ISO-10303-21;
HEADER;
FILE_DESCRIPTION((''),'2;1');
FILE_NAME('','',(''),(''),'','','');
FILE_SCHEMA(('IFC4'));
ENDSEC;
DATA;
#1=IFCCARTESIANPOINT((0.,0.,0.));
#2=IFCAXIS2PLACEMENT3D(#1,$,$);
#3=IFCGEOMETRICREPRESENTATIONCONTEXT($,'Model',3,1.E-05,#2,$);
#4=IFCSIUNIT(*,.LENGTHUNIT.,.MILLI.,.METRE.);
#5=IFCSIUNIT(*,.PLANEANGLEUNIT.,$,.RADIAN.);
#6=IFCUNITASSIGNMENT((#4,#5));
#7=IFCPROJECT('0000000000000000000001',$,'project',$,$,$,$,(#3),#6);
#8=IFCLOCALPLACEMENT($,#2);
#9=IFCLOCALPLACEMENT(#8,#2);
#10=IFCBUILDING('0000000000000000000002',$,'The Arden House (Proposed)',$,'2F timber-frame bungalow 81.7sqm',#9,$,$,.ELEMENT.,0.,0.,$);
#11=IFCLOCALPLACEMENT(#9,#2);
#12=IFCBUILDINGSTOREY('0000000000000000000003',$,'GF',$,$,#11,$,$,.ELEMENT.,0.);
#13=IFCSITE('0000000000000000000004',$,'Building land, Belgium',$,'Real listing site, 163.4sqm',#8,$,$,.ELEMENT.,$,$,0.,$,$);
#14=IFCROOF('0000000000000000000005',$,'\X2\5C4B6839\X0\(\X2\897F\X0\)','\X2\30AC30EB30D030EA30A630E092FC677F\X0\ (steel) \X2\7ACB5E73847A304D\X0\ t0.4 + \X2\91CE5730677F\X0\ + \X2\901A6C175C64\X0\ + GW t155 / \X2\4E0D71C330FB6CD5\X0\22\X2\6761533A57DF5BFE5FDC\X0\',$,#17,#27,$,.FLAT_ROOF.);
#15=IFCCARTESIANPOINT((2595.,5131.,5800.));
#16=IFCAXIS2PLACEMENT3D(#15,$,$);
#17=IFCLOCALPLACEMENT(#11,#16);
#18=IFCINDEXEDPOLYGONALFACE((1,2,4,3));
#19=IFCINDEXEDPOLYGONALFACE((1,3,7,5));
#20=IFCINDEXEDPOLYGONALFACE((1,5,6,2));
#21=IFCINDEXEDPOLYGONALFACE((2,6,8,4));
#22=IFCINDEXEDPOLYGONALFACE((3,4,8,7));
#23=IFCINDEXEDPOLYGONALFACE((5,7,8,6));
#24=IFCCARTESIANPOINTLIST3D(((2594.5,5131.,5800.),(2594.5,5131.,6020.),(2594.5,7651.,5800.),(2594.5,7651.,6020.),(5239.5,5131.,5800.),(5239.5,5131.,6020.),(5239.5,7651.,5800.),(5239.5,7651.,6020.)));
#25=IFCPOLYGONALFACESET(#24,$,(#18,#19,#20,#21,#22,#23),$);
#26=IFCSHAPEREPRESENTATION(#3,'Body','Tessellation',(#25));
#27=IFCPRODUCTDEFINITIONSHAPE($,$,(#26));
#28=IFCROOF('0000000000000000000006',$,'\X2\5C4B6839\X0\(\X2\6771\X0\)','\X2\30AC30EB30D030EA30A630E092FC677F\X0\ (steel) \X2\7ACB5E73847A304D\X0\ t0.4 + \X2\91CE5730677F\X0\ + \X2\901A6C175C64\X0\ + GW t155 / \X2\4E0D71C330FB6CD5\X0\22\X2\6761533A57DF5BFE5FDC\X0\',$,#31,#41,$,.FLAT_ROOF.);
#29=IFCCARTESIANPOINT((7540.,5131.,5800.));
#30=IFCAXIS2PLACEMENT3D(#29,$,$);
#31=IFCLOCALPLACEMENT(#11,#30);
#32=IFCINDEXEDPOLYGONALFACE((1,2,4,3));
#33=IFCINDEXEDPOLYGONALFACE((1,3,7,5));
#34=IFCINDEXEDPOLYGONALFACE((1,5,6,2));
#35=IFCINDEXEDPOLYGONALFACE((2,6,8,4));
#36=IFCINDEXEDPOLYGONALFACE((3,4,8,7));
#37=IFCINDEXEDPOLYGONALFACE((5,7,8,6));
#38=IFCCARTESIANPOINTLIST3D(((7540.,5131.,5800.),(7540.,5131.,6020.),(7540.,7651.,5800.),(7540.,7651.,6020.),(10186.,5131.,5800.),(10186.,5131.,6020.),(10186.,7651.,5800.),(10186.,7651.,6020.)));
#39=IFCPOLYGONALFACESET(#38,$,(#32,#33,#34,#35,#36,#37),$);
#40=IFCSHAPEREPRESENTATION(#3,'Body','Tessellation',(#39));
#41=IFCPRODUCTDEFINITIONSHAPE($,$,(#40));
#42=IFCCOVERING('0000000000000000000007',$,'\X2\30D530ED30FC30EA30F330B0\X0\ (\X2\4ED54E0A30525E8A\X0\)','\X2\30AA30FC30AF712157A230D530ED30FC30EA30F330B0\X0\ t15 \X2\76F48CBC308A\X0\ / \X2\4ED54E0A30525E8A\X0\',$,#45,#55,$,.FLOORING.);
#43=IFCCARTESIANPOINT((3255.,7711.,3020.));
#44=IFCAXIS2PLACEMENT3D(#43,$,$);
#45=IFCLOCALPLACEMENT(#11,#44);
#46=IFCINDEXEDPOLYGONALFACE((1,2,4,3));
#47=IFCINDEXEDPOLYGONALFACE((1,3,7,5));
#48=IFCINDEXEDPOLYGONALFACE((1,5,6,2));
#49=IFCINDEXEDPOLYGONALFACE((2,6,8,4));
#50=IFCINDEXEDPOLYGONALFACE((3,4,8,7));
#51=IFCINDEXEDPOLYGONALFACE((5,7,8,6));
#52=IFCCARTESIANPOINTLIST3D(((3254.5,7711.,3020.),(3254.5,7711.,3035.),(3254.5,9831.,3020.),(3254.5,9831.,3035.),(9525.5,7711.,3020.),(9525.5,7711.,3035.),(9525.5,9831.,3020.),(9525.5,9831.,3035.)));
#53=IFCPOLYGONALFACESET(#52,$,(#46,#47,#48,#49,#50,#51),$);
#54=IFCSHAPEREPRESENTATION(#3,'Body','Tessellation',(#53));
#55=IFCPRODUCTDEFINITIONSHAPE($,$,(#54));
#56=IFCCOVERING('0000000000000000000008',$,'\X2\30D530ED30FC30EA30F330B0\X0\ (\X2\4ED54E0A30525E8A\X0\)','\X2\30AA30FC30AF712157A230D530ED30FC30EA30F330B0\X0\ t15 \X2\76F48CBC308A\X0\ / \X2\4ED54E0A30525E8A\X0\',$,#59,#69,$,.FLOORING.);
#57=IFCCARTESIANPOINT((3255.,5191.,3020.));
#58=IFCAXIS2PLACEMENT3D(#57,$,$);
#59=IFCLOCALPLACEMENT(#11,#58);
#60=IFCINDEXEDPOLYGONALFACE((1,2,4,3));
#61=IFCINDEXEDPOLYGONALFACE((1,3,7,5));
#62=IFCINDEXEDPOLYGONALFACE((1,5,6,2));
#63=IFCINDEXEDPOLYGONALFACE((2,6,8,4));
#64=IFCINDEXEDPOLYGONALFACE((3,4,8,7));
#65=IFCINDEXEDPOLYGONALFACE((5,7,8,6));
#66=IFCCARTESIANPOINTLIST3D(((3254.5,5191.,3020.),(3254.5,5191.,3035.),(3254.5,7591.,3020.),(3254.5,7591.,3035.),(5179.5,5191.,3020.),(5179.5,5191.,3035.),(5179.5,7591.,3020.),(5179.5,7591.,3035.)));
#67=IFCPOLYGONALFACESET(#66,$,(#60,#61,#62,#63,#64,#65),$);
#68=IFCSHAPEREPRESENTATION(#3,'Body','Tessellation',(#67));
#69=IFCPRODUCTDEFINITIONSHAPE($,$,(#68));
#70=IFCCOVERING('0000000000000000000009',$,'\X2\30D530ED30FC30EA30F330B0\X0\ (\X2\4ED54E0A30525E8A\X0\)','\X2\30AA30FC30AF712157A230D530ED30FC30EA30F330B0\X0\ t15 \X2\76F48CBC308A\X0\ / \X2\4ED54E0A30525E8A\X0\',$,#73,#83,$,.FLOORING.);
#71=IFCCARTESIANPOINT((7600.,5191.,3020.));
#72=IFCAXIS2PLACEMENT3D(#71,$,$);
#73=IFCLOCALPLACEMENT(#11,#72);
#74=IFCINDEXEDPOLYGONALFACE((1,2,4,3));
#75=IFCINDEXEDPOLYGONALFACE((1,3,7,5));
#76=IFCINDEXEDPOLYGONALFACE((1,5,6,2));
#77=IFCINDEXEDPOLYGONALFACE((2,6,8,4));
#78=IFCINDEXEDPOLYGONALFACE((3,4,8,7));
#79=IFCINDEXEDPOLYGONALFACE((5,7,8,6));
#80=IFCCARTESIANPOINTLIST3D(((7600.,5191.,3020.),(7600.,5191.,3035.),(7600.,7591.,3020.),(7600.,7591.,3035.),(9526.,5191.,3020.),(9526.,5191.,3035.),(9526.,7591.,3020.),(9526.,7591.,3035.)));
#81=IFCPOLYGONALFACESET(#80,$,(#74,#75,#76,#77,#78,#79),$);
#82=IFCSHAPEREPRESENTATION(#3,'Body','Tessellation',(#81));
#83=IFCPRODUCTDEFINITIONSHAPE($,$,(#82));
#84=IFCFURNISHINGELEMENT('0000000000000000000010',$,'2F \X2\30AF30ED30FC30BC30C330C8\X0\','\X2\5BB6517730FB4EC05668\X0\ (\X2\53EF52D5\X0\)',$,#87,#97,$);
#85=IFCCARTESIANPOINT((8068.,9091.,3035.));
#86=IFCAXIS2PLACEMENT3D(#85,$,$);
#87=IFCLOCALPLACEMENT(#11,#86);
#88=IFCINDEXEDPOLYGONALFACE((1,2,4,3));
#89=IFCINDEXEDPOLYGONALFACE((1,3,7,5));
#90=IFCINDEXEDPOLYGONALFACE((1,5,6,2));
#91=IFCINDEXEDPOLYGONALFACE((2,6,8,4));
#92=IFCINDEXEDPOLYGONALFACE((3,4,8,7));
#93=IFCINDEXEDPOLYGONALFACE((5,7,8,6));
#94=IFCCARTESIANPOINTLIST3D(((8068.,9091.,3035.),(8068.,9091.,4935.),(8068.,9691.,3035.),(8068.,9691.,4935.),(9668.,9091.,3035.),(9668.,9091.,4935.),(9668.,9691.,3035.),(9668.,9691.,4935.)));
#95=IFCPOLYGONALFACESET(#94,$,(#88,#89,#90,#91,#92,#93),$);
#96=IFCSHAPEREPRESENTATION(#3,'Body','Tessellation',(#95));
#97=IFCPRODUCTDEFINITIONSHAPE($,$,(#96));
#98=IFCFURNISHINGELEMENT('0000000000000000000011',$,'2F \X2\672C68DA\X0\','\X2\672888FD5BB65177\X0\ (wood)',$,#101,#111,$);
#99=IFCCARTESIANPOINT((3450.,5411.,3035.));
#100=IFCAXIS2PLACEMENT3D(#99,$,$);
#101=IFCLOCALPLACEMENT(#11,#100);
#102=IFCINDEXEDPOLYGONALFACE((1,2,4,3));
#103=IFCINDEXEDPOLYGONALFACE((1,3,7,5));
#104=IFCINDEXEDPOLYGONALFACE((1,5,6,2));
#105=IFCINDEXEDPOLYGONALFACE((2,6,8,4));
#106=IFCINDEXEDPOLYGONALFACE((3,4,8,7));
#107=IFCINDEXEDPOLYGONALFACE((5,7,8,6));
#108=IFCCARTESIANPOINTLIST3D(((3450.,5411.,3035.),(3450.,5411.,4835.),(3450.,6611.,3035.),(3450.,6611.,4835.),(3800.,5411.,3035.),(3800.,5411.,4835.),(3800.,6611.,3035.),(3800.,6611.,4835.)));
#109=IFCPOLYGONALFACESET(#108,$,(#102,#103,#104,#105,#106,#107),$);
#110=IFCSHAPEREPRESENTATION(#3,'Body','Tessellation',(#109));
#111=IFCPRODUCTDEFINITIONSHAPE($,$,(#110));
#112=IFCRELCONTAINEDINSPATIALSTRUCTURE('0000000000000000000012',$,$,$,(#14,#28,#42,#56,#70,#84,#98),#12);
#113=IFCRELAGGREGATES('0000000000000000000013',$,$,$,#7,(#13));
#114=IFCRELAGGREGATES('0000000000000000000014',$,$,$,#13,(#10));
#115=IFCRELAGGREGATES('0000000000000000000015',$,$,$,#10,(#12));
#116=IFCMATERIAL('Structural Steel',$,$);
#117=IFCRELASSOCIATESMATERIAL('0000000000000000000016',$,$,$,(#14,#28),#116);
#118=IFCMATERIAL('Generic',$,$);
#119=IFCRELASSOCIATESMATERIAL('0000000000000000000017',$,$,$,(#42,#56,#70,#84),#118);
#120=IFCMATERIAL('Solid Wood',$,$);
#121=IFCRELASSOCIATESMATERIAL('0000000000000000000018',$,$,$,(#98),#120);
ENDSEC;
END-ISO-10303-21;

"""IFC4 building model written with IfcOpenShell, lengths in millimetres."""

from ifc_helpers import new_model, si_unit, frame, frame_2d, origin, place, context, project, spatial, rectangle, extrude, material, element, save


model = new_model("IFC4")

# Units and contexts
model_context = context("Model", 3, precision=1e-05, world=origin())
ifc_project = project(units=[si_unit("LENGTHUNIT", "METRE", prefix="MILLI"), si_unit("PLANEANGLEUNIT", "RADIAN")], contexts=[model_context])

# Site, building, storey
site_placement = place(None, origin())
site = spatial("IfcSite", under=ifc_project, at=site_placement, Name="Building land, Belgium", ObjectType="Real listing site, 163.4sqm", CompositionType="ELEMENT", RefElevation=0.0)
building_placement = place(site_placement, origin())
building = spatial("IfcBuilding", under=site, at=building_placement, Name="The Arden House (Proposed)", ObjectType="2F timber-frame bungalow 81.7sqm", CompositionType="ELEMENT", ElevationOfRefHeight=0.0, ElevationOfTerrain=0.0)
storey_placement = place(building_placement, origin())
storey = spatial("IfcBuildingStorey", under=building, at=storey_placement, Name="GF", CompositionType="ELEMENT", Elevation=0.0)

# Shared definitions
ifc_material_1 = material(Name="Solid Wood")

# Roofs
ifc_material_2 = material(Name="Structural Steel")
roof_1_placement = place(storey_placement, frame((2595.0, 5131.0, 5800.0)))
element("IfcRoof", 1, at=roof_1_placement, inside=storey, material=ifc_material_2, Name="屋根(西)", Description="ガルバリウム鋼板 (steel) 立平葺き t0.4 + 野地板 + 通気層 + GW t155 / 不燃・法22条区域対応", PredefinedType="FLAT_ROOF", context=model_context, shape_type="SweptSolid", body=[
    extrude(rectangle(XDim=2645.0, YDim=2520.0, at=frame_2d((1322.0, 1260.0))), frame((2595.0, 5131.0, 5800.0)), (0.0, 0.0, 1.0), 220.0),
])
roof_2_placement = place(storey_placement, frame((7540.0, 5131.0, 5800.0)))
element("IfcRoof", 2, at=roof_2_placement, inside=storey, material=ifc_material_2, Name="屋根(東)", Description="ガルバリウム鋼板 (steel) 立平葺き t0.4 + 野地板 + 通気層 + GW t155 / 不燃・法22条区域対応", PredefinedType="FLAT_ROOF", context=model_context, shape_type="SweptSolid", body=[
    extrude(rectangle(XDim=2646.0, YDim=2520.0, at=frame_2d((1323.0, 1260.0))), frame((7540.0, 5131.0, 5800.0)), (0.0, 0.0, 1.0), 220.0),
])

# Coverings
ifc_material_3 = material(Name="Generic")
covering_1_placement = place(storey_placement, frame((3255.0, 7711.0, 3020.0)))
element("IfcCovering", 3, at=covering_1_placement, inside=storey, material=ifc_material_3, Name="フローリング (仕上げ床)", Description="オーク無垢フローリング t15 直貼り / 仕上げ床", PredefinedType="FLOORING", context=model_context, shape_type="SweptSolid", body=[
    extrude(rectangle(XDim=6271.0, YDim=2120.0, at=frame_2d((3135.0, 1060.0))), frame((3255.0, 7711.0, 3020.0)), (0.0, 0.0, 1.0), 15.0),
])
covering_2_placement = place(storey_placement, frame((3255.0, 5191.0, 3020.0)))
element("IfcCovering", 4, at=covering_2_placement, inside=storey, material=ifc_material_3, Name="フローリング (仕上げ床)", Description="オーク無垢フローリング t15 直貼り / 仕上げ床", PredefinedType="FLOORING", context=model_context, shape_type="SweptSolid", body=[
    extrude(rectangle(XDim=1925.0, YDim=2400.0, at=frame_2d((962.0, 1200.0))), frame((3255.0, 5191.0, 3020.0)), (0.0, 0.0, 1.0), 15.0),
])
covering_3_placement = place(storey_placement, frame((7600.0, 5191.0, 3020.0)))
element("IfcCovering", 5, at=covering_3_placement, inside=storey, material=ifc_material_3, Name="フローリング (仕上げ床)", Description="オーク無垢フローリング t15 直貼り / 仕上げ床", PredefinedType="FLOORING", context=model_context, shape_type="SweptSolid", body=[
    extrude(rectangle(XDim=1926.0, YDim=2400.0, at=frame_2d((963.0, 1200.0))), frame((7600.0, 5191.0, 3020.0)), (0.0, 0.0, 1.0), 15.0),
])

# Furnishing elements
furnishing_1_placement = place(storey_placement, frame((8068.0, 9091.0, 3035.0)))
element("IfcFurnishingElement", 6, at=furnishing_1_placement, inside=storey, material=ifc_material_3, Name="2F クローゼット", Description="家具・什器 (可動)", context=model_context, shape_type="SweptSolid", body=[
    extrude(rectangle(XDim=1600.0, YDim=600.0, at=frame_2d((800.0, 300.0))), frame((8068.0, 9091.0, 3035.0)), (0.0, 0.0, 1.0), 1900.0),
])
furnishing_2_placement = place(storey_placement, frame((3450.0, 5411.0, 3035.0)))
element("IfcFurnishingElement", 7, at=furnishing_2_placement, inside=storey, material=ifc_material_1, Name="2F 本棚", Description="木製家具 (wood)", context=model_context, shape_type="SweptSolid", body=[
    extrude(rectangle(XDim=350.0, YDim=1200.0, at=frame_2d((175.0, 600.0))), frame((3450.0, 5411.0, 3035.0)), (0.0, 0.0, 1.0), 1800.0),
])

save(model, "model.ifc")
